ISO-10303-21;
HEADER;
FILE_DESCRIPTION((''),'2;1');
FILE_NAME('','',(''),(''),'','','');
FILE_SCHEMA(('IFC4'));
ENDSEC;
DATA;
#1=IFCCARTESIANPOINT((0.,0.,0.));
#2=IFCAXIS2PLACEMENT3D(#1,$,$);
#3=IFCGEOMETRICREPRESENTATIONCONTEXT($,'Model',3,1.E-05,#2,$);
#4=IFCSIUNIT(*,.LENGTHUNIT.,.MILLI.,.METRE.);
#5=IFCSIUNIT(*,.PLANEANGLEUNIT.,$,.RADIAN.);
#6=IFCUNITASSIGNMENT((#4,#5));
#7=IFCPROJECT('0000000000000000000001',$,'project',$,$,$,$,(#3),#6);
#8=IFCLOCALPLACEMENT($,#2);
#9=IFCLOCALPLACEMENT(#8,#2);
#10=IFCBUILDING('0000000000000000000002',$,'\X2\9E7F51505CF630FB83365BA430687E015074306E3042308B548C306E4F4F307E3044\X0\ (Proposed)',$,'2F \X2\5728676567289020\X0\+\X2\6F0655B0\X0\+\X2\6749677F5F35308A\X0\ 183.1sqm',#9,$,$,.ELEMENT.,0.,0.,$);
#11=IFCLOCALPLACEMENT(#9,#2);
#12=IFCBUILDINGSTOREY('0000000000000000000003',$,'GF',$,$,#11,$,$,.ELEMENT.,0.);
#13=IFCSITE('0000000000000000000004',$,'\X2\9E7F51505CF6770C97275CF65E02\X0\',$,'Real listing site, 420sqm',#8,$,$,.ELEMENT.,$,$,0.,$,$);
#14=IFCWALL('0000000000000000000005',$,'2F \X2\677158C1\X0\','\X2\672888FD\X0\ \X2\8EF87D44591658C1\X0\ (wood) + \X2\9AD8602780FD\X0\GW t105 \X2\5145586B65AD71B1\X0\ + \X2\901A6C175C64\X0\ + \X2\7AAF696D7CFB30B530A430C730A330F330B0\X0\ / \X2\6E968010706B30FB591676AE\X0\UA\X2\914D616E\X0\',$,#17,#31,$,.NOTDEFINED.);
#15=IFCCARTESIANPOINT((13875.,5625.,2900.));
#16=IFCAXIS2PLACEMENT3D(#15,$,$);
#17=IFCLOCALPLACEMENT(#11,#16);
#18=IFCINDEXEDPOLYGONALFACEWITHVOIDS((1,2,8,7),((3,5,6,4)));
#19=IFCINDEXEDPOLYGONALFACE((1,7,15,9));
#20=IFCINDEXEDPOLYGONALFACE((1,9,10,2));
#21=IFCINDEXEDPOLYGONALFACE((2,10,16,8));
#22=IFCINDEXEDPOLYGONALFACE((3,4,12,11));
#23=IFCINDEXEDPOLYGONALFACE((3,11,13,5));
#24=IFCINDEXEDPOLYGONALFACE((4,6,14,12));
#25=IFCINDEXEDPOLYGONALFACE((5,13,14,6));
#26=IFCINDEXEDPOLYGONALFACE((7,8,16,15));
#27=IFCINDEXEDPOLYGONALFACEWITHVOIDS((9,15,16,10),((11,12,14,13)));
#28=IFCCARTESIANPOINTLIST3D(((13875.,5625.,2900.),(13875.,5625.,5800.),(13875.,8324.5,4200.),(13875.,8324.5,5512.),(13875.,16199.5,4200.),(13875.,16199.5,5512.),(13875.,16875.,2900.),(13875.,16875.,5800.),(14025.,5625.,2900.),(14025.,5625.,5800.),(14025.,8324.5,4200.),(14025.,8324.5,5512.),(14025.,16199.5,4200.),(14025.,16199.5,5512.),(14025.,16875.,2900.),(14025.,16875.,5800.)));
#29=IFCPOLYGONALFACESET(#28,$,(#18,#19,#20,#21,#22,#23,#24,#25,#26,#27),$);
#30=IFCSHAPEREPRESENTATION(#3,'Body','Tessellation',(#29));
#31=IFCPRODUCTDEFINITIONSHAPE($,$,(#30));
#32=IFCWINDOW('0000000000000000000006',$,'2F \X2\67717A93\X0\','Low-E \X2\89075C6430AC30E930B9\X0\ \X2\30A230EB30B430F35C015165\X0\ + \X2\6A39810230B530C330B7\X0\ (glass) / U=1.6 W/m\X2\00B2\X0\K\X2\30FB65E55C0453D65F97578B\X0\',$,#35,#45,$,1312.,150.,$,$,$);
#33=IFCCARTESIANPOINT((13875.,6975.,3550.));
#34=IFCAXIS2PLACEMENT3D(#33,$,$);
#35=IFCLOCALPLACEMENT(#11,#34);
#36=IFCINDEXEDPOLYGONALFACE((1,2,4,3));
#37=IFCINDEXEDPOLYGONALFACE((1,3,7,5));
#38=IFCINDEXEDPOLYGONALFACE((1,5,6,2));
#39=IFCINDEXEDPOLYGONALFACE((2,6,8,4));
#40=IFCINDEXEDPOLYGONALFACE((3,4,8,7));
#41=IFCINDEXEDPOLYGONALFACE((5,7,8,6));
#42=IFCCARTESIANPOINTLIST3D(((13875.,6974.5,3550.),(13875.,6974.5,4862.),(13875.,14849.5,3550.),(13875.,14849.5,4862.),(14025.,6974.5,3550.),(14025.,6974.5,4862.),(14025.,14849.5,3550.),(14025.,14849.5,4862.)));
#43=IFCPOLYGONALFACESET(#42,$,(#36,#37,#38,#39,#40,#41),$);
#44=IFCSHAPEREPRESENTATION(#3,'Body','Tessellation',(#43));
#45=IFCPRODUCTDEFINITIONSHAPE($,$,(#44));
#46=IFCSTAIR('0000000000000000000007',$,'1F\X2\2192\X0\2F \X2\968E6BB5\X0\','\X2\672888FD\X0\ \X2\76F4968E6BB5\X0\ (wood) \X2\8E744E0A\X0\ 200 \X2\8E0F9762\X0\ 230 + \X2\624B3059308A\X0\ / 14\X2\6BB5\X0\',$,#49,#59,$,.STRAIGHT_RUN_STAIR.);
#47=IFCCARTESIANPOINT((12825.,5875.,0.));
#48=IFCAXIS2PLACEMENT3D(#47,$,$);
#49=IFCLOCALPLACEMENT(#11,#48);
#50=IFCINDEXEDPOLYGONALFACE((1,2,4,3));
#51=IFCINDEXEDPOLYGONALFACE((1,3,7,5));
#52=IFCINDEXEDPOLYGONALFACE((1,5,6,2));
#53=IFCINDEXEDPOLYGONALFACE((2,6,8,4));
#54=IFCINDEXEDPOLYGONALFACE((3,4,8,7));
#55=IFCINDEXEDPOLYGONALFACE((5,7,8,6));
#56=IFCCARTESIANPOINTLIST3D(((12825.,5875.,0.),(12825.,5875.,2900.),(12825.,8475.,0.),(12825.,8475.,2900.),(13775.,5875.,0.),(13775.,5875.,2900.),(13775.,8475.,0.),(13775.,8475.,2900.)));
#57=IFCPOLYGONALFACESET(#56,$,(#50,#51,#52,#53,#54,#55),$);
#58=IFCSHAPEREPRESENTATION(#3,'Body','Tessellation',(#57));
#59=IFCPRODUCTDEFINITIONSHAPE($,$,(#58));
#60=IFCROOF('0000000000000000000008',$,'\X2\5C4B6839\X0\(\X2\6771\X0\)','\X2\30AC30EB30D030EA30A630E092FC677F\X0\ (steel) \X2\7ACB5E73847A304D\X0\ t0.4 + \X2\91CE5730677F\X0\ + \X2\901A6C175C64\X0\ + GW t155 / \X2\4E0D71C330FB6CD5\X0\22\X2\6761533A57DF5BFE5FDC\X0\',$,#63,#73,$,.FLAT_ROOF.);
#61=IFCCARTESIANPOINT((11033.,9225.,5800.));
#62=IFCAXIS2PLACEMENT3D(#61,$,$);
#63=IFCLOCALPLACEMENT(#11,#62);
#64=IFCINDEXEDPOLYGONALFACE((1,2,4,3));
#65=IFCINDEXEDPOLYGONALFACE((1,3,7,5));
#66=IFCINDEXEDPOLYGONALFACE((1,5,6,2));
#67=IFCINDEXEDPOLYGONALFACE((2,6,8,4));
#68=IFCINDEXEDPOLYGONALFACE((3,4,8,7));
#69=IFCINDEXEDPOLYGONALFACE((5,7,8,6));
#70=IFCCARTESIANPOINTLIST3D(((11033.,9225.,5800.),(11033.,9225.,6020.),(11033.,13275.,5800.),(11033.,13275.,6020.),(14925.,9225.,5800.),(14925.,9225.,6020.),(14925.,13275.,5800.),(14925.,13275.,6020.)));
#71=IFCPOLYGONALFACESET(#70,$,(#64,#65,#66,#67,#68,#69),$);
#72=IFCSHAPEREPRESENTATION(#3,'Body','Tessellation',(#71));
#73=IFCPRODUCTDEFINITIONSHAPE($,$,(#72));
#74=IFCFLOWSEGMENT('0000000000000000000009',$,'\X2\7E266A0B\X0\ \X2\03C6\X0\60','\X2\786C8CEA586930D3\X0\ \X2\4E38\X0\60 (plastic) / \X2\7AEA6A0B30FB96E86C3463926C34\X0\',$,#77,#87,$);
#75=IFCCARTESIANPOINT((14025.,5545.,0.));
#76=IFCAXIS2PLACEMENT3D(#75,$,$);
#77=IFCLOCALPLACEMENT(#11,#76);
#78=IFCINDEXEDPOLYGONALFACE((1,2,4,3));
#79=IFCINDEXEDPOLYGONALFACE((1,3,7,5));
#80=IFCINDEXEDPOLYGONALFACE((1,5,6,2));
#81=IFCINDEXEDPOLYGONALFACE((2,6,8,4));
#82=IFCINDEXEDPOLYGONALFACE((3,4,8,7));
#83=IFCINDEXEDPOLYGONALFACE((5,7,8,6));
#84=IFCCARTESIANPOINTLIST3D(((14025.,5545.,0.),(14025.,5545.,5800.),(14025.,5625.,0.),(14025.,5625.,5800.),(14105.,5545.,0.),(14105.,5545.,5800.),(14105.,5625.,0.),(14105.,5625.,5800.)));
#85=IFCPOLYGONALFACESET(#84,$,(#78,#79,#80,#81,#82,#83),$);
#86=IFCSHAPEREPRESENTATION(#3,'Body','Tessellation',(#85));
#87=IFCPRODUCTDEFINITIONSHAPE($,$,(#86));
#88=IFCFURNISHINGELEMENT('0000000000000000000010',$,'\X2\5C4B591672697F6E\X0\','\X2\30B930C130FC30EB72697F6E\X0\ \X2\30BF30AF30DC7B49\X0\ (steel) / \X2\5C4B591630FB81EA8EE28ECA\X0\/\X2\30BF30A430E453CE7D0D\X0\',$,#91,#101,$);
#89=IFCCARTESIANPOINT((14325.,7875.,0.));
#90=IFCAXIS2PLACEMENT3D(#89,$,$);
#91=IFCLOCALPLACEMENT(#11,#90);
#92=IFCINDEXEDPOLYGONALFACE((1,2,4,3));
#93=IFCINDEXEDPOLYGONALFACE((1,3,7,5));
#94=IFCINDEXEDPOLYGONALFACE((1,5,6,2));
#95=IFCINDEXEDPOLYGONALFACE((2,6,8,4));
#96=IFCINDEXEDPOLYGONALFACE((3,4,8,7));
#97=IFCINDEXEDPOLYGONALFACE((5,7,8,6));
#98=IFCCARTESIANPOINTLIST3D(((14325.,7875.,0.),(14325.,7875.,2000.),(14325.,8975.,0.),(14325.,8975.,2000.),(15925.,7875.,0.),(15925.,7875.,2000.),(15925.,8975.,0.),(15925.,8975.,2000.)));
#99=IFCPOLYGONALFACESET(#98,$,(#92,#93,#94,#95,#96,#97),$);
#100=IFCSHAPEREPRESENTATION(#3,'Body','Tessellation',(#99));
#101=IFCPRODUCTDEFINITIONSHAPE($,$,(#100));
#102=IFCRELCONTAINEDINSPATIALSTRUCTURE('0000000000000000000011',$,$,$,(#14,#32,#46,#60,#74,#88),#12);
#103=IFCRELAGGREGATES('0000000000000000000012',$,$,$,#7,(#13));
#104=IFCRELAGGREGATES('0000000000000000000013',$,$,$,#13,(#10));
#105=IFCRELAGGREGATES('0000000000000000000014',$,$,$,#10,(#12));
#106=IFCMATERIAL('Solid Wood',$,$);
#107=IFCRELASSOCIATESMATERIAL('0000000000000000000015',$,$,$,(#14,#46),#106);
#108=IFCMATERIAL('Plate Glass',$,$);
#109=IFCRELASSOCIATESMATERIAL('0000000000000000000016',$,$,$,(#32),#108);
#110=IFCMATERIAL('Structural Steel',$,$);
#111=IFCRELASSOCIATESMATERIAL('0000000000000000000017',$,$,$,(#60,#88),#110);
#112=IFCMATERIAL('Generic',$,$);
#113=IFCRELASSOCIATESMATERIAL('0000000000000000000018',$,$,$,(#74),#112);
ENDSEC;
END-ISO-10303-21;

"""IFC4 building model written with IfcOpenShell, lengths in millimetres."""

from ifc_helpers import new_model, si_unit, frame, frame_2d, origin, place, context, project, spatial, rectangle, extrude, material, element, fill, save


model = new_model("IFC4")

# Units and contexts
model_context = context("Model", 3, precision=1e-05, world=origin())
ifc_project = project(units=[si_unit("LENGTHUNIT", "METRE", prefix="MILLI"), si_unit("PLANEANGLEUNIT", "RADIAN")], contexts=[model_context])

# Site, building, storey
site_placement = place(None, origin())
site = spatial("IfcSite", under=ifc_project, at=site_placement, Name="鹿児島県霧島市", ObjectType="Real listing site, 420sqm", CompositionType="ELEMENT", RefElevation=0.0)
building_placement = place(site_placement, origin())
building = spatial("IfcBuilding", under=site, at=building_placement, Name="鹿児島・茶室と縁側のある和の住まい (Proposed)", ObjectType="2F 在来木造+漆喰+杉板張り 183.1sqm", CompositionType="ELEMENT", ElevationOfRefHeight=0.0, ElevationOfTerrain=0.0)
storey_placement = place(building_placement, origin())
storey = spatial("IfcBuildingStorey", under=building, at=storey_placement, Name="GF", CompositionType="ELEMENT", Elevation=0.0)

# Shared definitions
ifc_material_1 = material(Name="Solid Wood")

# Wall, opening, window
ifc_material_2 = material(Name="Plate Glass")
wall_1_placement = place(storey_placement, frame((13875.0, 5625.0, 2900.0)))
wall_1 = element("IfcWall", 1, at=wall_1_placement, inside=storey, material=ifc_material_1, Name="2F 東壁", Description="木製 軸組外壁 (wood) + 高性能GW t105 充填断熱 + 通気層 + 窯業系サイディング / 準耐火・外皮UA配慮", PredefinedType="NOTDEFINED", context=model_context, shape_type="SweptSolid", body=[
    extrude(rectangle(XDim=150.0, YDim=11250.0, at=frame_2d((75.0, 5625.0))), frame((13875.0, 5625.0, 2900.0)), (0.0, 0.0, 1.0), 2900.0),
])
opening_1_placement = place(storey_placement, frame((13875.0, 6975.0, 3550.0)))
opening_1 = element("IfcOpeningElement", 2, at=opening_1_placement, cuts=wall_1, PredefinedType="NOTDEFINED", context=model_context, shape_type="SweptSolid", body=[
    extrude(rectangle(XDim=150.0, YDim=7875.0, at=frame_2d((75.0, 3937.0))), frame((13875.0, 6975.0, 3550.0)), (0.0, 0.0, 1.0), 1312.0),
])
window_1_placement = place(storey_placement, frame((13875.0, 6975.0, 3550.0)))
window_1 = element("IfcWindow", 3, at=window_1_placement, inside=storey, material=ifc_material_2, Name="2F 東窓", Description="Low-E 複層ガラス アルゴン封入 + 樹脂サッシ (glass) / U=1.6 W/m²K・日射取得型", OverallHeight=1312.0, OverallWidth=150.0, context=model_context, shape_type="SweptSolid", body=[
    extrude(rectangle(XDim=150.0, YDim=7875.0, at=frame_2d((75.0, 3937.0))), frame((13875.0, 6975.0, 3550.0)), (0.0, 0.0, 1.0), 1312.0),
])
fill(opening_1, window_1)

# Stair
stair_placement = place(storey_placement, frame((12825.0, 5875.0, 0.0)))
element("IfcStair", 4, at=stair_placement, inside=storey, material=ifc_material_1, Name="1F→2F 階段", Description="木製 直階段 (wood) 蹴上 200 踏面 230 + 手すり / 14段", PredefinedType="STRAIGHT_RUN_STAIR", context=model_context, shape_type="SweptSolid", body=[
    extrude(rectangle(XDim=950.0, YDim=2600.0, at=frame_2d((475.0, 1300.0))), frame((12825.0, 5875.0, 0.0)), (0.0, 0.0, 1.0), 2900.0),
])

# Roof
ifc_material_3 = material(Name="Structural Steel")
roof_placement = place(storey_placement, frame((11033.0, 9225.0, 5800.0)))
element("IfcRoof", 5, at=roof_placement, inside=storey, material=ifc_material_3, Name="屋根(東)", Description="ガルバリウム鋼板 (steel) 立平葺き t0.4 + 野地板 + 通気層 + GW t155 / 不燃・法22条区域対応", PredefinedType="FLAT_ROOF", context=model_context, shape_type="SweptSolid", body=[
    extrude(rectangle(XDim=3892.0, YDim=4050.0, at=frame_2d((1946.0, 2025.0))), frame((11033.0, 9225.0, 5800.0)), (0.0, 0.0, 1.0), 220.0),
])

# Flow segment
ifc_material_4 = material(Name="Generic")
flow_segment_placement = place(storey_placement, frame((14025.0, 5545.0, 0.0)))
element("IfcFlowSegment", 6, at=flow_segment_placement, inside=storey, material=ifc_material_4, Name="縦樋 φ60", Description="硬質塩ビ 丸60 (plastic) / 竪樋・雨水排水", context=model_context, shape_type="SweptSolid", body=[
    extrude(rectangle(XDim=80.0, YDim=80.0, at=frame_2d((40.0, 40.0))), frame((14025.0, 5545.0, 0.0)), (0.0, 0.0, 1.0), 5800.0),
])

# Furnishing element
furnishing_placement = place(storey_placement, frame((14325.0, 7875.0, 0.0)))
element("IfcFurnishingElement", 7, at=furnishing_placement, inside=storey, material=ifc_material_3, Name="屋外物置", Description="スチール物置 タクボ等 (steel) / 屋外・自転車/タイヤ収納", context=model_context, shape_type="SweptSolid", body=[
    extrude(rectangle(XDim=1600.0, YDim=1100.0, at=frame_2d((800.0, 550.0))), frame((14325.0, 7875.0, 0.0)), (0.0, 0.0, 1.0), 2000.0),
])

save(model, "model.ifc")
